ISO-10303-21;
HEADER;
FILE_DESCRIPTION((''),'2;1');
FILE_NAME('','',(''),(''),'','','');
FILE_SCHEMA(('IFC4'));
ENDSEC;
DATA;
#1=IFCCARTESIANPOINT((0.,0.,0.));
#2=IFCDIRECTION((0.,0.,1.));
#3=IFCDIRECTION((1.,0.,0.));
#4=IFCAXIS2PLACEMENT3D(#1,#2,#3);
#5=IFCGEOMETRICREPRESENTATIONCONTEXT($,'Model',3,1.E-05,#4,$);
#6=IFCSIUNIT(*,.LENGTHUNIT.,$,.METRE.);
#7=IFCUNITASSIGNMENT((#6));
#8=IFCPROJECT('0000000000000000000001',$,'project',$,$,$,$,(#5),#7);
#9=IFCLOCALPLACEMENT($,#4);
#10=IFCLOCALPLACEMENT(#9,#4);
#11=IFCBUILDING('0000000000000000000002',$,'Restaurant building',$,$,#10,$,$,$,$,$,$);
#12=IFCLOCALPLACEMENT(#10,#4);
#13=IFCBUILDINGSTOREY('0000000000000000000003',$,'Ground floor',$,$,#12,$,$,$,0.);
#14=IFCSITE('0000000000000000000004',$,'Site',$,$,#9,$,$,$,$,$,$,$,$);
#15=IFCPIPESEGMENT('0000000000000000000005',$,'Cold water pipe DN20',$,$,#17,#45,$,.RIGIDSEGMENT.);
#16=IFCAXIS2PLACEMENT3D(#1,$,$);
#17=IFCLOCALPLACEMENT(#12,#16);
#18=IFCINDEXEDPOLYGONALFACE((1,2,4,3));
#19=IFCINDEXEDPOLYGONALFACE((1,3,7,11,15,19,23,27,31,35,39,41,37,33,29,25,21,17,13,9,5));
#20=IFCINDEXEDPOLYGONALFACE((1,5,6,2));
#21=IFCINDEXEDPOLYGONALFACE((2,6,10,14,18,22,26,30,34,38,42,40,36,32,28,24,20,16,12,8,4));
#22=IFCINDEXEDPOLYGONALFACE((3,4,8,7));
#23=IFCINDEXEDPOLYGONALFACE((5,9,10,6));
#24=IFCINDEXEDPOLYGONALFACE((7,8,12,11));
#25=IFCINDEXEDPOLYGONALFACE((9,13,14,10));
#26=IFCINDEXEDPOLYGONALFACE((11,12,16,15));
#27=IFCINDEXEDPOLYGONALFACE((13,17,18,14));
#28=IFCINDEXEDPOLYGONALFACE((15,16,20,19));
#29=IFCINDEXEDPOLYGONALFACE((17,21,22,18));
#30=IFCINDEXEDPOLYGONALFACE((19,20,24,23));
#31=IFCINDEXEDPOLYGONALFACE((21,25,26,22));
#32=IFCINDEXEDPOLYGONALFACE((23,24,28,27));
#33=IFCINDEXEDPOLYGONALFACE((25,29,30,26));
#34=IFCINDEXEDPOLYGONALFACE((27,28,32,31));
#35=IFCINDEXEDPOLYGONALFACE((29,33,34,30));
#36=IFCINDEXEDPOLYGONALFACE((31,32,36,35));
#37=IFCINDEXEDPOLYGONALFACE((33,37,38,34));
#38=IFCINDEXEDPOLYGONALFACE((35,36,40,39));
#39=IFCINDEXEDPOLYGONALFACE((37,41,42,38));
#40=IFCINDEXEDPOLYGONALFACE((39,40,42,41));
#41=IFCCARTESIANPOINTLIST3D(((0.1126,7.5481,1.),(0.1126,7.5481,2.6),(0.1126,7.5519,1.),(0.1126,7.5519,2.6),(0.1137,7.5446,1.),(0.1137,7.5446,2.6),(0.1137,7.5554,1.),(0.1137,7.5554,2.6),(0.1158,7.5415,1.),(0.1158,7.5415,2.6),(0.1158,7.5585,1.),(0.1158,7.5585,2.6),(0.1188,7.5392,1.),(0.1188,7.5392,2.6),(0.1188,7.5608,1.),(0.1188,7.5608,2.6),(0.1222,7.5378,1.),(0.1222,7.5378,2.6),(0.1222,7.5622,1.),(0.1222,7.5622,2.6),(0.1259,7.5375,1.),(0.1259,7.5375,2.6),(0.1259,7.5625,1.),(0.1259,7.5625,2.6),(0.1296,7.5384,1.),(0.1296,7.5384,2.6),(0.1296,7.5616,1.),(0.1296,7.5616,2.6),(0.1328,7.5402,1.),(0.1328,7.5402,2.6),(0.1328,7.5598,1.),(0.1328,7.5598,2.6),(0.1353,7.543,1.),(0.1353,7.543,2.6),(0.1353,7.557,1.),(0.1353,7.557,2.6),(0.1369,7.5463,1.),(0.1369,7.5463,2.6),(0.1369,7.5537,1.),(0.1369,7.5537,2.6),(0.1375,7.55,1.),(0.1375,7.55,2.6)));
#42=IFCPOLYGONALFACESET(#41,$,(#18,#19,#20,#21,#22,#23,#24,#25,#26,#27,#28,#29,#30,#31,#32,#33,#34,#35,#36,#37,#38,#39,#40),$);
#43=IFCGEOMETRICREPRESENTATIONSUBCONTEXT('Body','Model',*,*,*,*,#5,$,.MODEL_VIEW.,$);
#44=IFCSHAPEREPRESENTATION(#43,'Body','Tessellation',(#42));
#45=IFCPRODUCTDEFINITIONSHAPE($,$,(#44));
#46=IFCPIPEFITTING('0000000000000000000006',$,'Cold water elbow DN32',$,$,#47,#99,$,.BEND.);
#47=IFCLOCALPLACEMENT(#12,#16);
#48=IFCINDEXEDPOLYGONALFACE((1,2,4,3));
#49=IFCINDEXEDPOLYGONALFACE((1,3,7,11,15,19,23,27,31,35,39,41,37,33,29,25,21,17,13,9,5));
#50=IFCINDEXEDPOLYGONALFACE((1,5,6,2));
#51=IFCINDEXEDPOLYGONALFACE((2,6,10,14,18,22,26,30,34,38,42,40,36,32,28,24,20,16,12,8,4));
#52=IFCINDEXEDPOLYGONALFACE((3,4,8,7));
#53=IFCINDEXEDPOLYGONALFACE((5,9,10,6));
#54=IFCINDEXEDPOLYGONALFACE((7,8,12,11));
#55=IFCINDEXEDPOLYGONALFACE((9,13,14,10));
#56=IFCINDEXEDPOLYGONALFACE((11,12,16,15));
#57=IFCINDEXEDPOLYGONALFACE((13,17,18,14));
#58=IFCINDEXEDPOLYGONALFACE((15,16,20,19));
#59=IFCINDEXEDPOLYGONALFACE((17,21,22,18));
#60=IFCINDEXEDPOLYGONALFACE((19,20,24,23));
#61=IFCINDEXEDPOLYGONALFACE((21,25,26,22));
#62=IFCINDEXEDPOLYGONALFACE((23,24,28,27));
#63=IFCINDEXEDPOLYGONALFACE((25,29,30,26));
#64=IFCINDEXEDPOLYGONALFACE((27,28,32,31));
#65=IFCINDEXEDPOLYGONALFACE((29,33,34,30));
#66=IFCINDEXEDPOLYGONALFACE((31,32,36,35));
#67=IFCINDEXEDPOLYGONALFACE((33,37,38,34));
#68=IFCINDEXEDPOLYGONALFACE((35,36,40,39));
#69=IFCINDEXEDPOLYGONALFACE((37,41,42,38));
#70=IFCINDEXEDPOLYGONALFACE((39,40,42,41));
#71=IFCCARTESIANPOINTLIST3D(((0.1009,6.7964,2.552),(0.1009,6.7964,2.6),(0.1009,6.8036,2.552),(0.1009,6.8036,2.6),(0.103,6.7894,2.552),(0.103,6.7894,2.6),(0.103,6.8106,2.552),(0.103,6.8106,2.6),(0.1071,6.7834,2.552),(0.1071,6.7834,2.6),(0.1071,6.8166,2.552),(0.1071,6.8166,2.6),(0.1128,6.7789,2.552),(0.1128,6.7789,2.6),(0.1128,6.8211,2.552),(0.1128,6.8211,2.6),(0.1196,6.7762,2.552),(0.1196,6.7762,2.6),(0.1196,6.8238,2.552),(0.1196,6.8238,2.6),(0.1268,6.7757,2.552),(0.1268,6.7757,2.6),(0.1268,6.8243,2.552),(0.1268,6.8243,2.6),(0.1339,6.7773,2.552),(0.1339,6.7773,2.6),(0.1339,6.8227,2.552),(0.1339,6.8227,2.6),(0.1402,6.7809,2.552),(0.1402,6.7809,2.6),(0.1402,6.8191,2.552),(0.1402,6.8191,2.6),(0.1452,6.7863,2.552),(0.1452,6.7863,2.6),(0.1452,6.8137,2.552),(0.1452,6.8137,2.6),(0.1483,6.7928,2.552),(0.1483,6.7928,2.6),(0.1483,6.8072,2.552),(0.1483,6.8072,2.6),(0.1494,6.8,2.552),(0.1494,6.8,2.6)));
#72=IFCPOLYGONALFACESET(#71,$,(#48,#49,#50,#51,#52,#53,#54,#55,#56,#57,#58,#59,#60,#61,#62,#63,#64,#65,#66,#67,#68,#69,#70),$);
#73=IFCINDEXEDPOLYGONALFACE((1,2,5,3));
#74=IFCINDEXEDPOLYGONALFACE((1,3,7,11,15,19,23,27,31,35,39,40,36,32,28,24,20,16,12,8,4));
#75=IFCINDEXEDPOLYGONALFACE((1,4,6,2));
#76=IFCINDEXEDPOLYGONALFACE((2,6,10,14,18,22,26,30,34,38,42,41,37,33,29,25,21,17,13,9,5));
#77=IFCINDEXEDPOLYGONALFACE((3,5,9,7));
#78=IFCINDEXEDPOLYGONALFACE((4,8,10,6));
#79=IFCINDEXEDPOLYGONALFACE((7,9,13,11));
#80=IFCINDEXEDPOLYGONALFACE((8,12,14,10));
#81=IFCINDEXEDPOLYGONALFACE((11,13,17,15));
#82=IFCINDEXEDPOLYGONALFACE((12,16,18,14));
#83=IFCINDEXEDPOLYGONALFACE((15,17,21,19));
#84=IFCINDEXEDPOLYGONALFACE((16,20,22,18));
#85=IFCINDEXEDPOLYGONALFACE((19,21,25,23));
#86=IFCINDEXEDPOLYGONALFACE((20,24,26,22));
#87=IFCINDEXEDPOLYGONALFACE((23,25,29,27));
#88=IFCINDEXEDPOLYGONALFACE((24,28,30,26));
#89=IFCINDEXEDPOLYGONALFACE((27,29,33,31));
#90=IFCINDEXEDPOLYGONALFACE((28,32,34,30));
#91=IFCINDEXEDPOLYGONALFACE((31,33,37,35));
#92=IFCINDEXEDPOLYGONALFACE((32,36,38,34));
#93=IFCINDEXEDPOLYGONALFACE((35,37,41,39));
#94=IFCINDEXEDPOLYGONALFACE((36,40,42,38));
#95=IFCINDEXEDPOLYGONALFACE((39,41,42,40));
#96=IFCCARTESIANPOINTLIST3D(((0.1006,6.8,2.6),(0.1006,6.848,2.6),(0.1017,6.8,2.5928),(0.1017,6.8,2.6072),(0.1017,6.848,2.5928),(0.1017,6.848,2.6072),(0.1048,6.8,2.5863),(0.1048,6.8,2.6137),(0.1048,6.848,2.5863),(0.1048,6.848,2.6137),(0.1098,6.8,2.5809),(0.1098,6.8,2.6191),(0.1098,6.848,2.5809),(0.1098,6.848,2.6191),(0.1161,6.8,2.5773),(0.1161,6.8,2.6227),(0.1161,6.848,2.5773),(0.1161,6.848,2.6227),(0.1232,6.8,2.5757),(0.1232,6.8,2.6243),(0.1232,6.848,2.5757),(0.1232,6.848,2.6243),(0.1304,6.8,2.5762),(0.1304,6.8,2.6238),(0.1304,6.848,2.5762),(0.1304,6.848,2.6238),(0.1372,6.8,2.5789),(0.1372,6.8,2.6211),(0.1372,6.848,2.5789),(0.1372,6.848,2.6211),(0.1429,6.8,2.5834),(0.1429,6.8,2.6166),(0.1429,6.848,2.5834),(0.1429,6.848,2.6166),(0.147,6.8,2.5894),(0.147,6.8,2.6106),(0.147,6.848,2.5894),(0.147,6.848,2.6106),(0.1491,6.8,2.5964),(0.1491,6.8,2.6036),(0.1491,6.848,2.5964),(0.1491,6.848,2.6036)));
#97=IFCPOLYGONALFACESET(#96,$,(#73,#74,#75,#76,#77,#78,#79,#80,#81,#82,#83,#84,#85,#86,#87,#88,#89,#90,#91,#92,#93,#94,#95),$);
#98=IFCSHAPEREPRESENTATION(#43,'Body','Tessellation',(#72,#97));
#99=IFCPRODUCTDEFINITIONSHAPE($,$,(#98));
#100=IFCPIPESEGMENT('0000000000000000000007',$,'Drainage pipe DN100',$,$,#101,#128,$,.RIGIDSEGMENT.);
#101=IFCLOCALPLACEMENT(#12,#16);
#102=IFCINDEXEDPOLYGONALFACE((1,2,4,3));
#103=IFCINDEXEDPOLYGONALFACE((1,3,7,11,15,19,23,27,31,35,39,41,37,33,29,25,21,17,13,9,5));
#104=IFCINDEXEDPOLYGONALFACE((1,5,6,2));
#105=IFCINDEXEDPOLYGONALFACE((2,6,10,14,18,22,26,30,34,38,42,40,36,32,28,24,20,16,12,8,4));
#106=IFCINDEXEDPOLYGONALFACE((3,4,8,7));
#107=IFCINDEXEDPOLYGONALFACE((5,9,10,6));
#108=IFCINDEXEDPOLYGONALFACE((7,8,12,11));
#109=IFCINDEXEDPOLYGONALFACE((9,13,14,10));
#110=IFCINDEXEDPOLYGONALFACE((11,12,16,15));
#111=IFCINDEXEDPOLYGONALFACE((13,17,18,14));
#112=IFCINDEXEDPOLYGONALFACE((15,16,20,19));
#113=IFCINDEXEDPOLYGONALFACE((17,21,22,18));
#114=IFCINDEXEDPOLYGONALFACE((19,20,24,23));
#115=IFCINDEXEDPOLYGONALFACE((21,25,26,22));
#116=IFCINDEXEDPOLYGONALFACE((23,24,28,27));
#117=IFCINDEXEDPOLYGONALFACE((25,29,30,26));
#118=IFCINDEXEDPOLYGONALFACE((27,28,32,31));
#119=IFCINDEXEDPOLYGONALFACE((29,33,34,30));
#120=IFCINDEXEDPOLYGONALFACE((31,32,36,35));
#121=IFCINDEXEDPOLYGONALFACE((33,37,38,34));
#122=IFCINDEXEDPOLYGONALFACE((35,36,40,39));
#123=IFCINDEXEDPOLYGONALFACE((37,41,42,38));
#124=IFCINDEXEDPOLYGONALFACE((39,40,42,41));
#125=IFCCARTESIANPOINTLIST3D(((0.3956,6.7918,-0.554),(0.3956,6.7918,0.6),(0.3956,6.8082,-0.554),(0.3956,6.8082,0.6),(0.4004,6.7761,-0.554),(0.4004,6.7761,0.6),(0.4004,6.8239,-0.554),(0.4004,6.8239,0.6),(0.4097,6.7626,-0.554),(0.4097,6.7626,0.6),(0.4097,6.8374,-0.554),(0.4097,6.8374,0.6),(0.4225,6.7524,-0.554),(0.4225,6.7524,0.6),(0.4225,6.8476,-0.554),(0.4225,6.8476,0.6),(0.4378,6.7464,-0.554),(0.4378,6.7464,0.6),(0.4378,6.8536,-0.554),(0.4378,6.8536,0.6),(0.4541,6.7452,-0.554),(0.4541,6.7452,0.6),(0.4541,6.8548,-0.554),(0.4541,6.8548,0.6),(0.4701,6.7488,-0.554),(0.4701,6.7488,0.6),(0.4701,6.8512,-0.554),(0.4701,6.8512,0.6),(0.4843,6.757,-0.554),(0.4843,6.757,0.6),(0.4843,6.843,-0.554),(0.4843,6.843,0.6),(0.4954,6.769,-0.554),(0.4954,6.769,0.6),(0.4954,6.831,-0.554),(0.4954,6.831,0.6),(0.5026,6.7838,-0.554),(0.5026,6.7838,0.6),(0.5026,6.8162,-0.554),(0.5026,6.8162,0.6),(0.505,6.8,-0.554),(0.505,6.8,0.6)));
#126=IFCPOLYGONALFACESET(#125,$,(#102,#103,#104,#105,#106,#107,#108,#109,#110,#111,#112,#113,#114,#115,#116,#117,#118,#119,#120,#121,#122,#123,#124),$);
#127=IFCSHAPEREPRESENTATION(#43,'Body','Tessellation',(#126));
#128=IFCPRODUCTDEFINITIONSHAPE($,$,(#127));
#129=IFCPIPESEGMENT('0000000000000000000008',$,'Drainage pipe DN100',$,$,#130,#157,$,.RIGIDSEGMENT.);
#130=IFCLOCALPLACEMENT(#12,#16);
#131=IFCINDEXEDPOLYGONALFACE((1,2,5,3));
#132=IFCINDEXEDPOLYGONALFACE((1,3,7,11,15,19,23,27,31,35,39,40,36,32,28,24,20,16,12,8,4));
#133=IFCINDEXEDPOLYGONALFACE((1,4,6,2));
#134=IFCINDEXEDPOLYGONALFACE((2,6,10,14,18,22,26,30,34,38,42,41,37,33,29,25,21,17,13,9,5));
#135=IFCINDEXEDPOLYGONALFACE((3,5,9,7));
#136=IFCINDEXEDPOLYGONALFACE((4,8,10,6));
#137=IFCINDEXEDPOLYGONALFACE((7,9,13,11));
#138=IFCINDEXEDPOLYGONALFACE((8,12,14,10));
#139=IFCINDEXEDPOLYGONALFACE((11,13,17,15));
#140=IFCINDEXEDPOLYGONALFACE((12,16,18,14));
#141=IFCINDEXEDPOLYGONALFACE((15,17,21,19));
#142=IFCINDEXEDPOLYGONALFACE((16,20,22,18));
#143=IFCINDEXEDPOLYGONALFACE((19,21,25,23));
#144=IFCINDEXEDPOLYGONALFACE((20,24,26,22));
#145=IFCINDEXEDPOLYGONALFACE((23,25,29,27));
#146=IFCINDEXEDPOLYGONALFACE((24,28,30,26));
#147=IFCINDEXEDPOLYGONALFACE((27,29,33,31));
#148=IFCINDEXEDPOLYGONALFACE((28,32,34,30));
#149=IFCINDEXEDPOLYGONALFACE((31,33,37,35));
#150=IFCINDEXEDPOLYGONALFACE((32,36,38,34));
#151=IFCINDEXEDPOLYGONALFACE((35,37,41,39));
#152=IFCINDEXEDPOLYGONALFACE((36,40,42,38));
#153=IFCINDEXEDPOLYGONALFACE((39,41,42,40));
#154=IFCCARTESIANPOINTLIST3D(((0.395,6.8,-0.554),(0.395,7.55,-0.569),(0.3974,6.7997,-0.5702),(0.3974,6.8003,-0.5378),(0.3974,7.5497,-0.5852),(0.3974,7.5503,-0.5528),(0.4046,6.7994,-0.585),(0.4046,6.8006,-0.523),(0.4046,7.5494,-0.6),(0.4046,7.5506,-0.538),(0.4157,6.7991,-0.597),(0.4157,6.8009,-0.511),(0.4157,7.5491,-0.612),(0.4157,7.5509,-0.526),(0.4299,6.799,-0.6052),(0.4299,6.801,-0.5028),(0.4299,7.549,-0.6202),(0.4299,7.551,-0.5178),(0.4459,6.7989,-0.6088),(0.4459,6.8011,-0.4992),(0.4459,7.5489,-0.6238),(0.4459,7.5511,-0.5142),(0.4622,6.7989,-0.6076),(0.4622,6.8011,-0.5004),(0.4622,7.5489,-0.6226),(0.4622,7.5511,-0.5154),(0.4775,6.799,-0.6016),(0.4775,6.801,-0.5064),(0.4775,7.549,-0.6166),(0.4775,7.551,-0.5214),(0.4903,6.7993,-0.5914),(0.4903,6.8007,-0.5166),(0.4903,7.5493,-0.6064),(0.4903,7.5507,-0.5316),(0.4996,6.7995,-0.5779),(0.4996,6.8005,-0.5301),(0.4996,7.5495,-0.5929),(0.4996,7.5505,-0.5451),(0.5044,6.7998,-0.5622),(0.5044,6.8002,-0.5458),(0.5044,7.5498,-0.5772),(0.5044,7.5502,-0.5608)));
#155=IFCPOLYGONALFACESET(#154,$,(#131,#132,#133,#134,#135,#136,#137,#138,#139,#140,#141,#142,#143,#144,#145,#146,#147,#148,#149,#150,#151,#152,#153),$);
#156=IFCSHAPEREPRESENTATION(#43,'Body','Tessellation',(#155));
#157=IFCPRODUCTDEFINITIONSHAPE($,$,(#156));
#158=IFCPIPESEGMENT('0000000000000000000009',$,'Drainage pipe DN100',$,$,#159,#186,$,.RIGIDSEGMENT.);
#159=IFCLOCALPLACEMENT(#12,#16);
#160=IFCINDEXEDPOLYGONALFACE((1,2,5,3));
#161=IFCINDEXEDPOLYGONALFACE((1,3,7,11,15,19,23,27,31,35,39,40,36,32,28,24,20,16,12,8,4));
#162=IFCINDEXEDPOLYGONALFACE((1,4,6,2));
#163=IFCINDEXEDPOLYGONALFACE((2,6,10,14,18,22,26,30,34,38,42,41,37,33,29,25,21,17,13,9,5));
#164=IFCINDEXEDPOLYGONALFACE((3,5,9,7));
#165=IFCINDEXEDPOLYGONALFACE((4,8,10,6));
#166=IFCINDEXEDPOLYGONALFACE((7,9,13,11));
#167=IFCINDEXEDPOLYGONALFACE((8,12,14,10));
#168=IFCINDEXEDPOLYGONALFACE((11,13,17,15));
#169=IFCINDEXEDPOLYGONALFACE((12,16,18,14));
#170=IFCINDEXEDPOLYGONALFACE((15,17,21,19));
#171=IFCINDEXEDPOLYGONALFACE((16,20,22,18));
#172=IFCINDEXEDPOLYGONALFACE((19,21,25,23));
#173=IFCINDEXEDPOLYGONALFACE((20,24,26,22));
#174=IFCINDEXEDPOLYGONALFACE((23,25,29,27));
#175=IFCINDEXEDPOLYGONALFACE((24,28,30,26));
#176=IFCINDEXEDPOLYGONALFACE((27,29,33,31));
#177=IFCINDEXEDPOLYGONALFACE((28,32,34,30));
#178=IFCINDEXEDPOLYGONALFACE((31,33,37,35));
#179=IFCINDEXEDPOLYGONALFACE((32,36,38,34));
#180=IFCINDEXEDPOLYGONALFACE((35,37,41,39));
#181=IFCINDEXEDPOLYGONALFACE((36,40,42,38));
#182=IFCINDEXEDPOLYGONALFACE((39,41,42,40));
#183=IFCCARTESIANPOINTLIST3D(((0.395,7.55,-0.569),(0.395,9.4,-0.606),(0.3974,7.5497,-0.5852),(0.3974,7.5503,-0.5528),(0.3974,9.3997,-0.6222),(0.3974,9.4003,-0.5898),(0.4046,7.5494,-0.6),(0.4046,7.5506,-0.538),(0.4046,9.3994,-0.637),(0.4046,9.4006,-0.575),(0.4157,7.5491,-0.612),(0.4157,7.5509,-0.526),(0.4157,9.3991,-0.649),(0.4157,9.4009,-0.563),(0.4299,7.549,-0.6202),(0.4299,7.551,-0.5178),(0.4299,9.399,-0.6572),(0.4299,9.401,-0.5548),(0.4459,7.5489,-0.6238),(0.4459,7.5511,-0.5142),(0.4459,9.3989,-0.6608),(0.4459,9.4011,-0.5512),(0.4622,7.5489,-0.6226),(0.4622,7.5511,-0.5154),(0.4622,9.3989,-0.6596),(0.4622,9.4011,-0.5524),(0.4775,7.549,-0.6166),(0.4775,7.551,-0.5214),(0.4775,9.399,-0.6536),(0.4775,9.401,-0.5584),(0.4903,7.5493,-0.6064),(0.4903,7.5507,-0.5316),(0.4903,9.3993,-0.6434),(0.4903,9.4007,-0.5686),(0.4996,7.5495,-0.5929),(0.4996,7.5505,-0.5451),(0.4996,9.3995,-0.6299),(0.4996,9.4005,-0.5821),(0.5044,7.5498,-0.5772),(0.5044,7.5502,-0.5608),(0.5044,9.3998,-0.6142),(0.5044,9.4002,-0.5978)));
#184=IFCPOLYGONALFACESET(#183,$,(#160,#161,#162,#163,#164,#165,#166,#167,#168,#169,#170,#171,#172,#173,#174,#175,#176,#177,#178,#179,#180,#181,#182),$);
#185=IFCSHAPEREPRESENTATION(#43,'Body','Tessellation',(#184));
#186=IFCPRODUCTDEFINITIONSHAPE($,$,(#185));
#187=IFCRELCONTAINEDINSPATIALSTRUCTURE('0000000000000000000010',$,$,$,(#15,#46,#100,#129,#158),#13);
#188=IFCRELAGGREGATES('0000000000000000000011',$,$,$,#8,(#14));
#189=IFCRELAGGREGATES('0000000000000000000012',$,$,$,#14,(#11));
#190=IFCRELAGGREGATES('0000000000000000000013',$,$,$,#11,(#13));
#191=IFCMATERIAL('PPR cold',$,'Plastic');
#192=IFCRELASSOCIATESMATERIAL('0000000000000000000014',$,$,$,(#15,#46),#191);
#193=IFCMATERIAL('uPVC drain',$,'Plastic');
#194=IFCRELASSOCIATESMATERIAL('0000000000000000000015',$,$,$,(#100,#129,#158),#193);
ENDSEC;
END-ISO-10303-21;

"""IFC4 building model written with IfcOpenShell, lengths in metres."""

from ifc_helpers import new_model, si_unit, frame, origin_with_axes, origin_2d, place, context, subcontext, project, spatial, circle, extrude, material, element, save


model = new_model("IFC4")

# Units and contexts
model_context = context("Model", 3, precision=1e-05, world=origin_with_axes())
body_context = subcontext(model_context, "Body", "Model", "MODEL_VIEW")
ifc_project = project(units=[si_unit("LENGTHUNIT", "METRE")], contexts=[model_context])

# Site, building, storey
site_placement = place(None, origin_with_axes())
site = spatial("IfcSite", under=ifc_project, at=site_placement, Name="Site")
building_placement = place(site_placement, origin_with_axes())
building = spatial("IfcBuilding", under=site, at=building_placement, Name="Restaurant building")
storey_placement = place(building_placement, origin_with_axes())
storey = spatial("IfcBuildingStorey", under=building, at=storey_placement, Name="Ground floor", Elevation=0.0)

# Pipe segment
ifc_material_1 = material(Name="PPR cold", Category="Plastic")
pipe_segment_1_placement = place(storey_placement, frame((0.125, 7.55, 2.6)))
element("IfcPipeSegment", 1, at=pipe_segment_1_placement, inside=storey, material=ifc_material_1, Name="Cold water pipe DN20", PredefinedType="RIGIDSEGMENT", context=body_context, shape_type="SweptSolid", body=[
    extrude(circle(Radius=0.0125, at=origin_2d()), frame((0.0, 0.0, 0.0), z_axis=(0.0, 0.0, -1.0), x_axis=(1.0, 0.0, 0.0)), (0.0, 0.0, 1.0), 1.6),
])

# Pipe fitting
pipe_fitting_1_placement = place(storey_placement, frame((0.125, 6.8, 2.6)))
element("IfcPipeFitting", 2, at=pipe_fitting_1_placement, inside=storey, material=ifc_material_1, Name="Cold water elbow DN32", PredefinedType="BEND", context=body_context, shape_type="SweptSolid", body=[
    extrude(circle(Radius=0.0244, at=origin_2d()), frame((0.0, 0.0, 0.0), z_axis=(0.0, 0.0, -1.0), x_axis=(1.0, 0.0, 0.0)), (0.0, 0.0, 1.0), 0.048),
    extrude(circle(Radius=0.0244, at=origin_2d()), frame((0.0, 0.0, 0.0), z_axis=(0.0, 1.0, 0.0), x_axis=(-1.0, 0.0, 0.0)), (0.0, 0.0, 1.0), 0.048),
])

# Pipe segments
ifc_material_2 = material(Name="uPVC drain", Category="Plastic")
pipe_segment_2_placement = place(storey_placement, frame((0.45, 6.8, 0.6)))
element("IfcPipeSegment", 3, at=pipe_segment_2_placement, inside=storey, material=ifc_material_2, Name="Drainage pipe DN100", PredefinedType="RIGIDSEGMENT", context=body_context, shape_type="SweptSolid", body=[
    extrude(circle(Radius=0.055, at=origin_2d()), frame((0.0, 0.0, 0.0), z_axis=(0.0, 0.0, -1.0), x_axis=(1.0, 0.0, 0.0)), (0.0, 0.0, 1.0), 1.154),
])
pipe_segment_3_placement = place(storey_placement, frame((0.45, 6.8, -0.554)))
element("IfcPipeSegment", 4, at=pipe_segment_3_placement, inside=storey, material=ifc_material_2, Name="Drainage pipe DN100", PredefinedType="RIGIDSEGMENT", context=body_context, shape_type="SweptSolid", body=[
    extrude(circle(Radius=0.055, at=origin_2d()), frame((0.0, 0.0, 0.0), z_axis=(0.0, 0.9998, -0.019996), x_axis=(-1.0, 0.0, 0.0)), (0.0, 0.0, 1.0), 0.7501),
])
pipe_segment_4_placement = place(storey_placement, frame((0.45, 7.55, -0.569)))
element("IfcPipeSegment", 5, at=pipe_segment_4_placement, inside=storey, material=ifc_material_2, Name="Drainage pipe DN100", PredefinedType="RIGIDSEGMENT", context=body_context, shape_type="SweptSolid", body=[
    extrude(circle(Radius=0.055, at=origin_2d()), frame((0.0, 0.0, 0.0), z_axis=(0.0, 0.9998, -0.019996), x_axis=(-1.0, 0.0, 0.0)), (0.0, 0.0, 1.0), 1.8504),
])

save(model, "model.ifc")
